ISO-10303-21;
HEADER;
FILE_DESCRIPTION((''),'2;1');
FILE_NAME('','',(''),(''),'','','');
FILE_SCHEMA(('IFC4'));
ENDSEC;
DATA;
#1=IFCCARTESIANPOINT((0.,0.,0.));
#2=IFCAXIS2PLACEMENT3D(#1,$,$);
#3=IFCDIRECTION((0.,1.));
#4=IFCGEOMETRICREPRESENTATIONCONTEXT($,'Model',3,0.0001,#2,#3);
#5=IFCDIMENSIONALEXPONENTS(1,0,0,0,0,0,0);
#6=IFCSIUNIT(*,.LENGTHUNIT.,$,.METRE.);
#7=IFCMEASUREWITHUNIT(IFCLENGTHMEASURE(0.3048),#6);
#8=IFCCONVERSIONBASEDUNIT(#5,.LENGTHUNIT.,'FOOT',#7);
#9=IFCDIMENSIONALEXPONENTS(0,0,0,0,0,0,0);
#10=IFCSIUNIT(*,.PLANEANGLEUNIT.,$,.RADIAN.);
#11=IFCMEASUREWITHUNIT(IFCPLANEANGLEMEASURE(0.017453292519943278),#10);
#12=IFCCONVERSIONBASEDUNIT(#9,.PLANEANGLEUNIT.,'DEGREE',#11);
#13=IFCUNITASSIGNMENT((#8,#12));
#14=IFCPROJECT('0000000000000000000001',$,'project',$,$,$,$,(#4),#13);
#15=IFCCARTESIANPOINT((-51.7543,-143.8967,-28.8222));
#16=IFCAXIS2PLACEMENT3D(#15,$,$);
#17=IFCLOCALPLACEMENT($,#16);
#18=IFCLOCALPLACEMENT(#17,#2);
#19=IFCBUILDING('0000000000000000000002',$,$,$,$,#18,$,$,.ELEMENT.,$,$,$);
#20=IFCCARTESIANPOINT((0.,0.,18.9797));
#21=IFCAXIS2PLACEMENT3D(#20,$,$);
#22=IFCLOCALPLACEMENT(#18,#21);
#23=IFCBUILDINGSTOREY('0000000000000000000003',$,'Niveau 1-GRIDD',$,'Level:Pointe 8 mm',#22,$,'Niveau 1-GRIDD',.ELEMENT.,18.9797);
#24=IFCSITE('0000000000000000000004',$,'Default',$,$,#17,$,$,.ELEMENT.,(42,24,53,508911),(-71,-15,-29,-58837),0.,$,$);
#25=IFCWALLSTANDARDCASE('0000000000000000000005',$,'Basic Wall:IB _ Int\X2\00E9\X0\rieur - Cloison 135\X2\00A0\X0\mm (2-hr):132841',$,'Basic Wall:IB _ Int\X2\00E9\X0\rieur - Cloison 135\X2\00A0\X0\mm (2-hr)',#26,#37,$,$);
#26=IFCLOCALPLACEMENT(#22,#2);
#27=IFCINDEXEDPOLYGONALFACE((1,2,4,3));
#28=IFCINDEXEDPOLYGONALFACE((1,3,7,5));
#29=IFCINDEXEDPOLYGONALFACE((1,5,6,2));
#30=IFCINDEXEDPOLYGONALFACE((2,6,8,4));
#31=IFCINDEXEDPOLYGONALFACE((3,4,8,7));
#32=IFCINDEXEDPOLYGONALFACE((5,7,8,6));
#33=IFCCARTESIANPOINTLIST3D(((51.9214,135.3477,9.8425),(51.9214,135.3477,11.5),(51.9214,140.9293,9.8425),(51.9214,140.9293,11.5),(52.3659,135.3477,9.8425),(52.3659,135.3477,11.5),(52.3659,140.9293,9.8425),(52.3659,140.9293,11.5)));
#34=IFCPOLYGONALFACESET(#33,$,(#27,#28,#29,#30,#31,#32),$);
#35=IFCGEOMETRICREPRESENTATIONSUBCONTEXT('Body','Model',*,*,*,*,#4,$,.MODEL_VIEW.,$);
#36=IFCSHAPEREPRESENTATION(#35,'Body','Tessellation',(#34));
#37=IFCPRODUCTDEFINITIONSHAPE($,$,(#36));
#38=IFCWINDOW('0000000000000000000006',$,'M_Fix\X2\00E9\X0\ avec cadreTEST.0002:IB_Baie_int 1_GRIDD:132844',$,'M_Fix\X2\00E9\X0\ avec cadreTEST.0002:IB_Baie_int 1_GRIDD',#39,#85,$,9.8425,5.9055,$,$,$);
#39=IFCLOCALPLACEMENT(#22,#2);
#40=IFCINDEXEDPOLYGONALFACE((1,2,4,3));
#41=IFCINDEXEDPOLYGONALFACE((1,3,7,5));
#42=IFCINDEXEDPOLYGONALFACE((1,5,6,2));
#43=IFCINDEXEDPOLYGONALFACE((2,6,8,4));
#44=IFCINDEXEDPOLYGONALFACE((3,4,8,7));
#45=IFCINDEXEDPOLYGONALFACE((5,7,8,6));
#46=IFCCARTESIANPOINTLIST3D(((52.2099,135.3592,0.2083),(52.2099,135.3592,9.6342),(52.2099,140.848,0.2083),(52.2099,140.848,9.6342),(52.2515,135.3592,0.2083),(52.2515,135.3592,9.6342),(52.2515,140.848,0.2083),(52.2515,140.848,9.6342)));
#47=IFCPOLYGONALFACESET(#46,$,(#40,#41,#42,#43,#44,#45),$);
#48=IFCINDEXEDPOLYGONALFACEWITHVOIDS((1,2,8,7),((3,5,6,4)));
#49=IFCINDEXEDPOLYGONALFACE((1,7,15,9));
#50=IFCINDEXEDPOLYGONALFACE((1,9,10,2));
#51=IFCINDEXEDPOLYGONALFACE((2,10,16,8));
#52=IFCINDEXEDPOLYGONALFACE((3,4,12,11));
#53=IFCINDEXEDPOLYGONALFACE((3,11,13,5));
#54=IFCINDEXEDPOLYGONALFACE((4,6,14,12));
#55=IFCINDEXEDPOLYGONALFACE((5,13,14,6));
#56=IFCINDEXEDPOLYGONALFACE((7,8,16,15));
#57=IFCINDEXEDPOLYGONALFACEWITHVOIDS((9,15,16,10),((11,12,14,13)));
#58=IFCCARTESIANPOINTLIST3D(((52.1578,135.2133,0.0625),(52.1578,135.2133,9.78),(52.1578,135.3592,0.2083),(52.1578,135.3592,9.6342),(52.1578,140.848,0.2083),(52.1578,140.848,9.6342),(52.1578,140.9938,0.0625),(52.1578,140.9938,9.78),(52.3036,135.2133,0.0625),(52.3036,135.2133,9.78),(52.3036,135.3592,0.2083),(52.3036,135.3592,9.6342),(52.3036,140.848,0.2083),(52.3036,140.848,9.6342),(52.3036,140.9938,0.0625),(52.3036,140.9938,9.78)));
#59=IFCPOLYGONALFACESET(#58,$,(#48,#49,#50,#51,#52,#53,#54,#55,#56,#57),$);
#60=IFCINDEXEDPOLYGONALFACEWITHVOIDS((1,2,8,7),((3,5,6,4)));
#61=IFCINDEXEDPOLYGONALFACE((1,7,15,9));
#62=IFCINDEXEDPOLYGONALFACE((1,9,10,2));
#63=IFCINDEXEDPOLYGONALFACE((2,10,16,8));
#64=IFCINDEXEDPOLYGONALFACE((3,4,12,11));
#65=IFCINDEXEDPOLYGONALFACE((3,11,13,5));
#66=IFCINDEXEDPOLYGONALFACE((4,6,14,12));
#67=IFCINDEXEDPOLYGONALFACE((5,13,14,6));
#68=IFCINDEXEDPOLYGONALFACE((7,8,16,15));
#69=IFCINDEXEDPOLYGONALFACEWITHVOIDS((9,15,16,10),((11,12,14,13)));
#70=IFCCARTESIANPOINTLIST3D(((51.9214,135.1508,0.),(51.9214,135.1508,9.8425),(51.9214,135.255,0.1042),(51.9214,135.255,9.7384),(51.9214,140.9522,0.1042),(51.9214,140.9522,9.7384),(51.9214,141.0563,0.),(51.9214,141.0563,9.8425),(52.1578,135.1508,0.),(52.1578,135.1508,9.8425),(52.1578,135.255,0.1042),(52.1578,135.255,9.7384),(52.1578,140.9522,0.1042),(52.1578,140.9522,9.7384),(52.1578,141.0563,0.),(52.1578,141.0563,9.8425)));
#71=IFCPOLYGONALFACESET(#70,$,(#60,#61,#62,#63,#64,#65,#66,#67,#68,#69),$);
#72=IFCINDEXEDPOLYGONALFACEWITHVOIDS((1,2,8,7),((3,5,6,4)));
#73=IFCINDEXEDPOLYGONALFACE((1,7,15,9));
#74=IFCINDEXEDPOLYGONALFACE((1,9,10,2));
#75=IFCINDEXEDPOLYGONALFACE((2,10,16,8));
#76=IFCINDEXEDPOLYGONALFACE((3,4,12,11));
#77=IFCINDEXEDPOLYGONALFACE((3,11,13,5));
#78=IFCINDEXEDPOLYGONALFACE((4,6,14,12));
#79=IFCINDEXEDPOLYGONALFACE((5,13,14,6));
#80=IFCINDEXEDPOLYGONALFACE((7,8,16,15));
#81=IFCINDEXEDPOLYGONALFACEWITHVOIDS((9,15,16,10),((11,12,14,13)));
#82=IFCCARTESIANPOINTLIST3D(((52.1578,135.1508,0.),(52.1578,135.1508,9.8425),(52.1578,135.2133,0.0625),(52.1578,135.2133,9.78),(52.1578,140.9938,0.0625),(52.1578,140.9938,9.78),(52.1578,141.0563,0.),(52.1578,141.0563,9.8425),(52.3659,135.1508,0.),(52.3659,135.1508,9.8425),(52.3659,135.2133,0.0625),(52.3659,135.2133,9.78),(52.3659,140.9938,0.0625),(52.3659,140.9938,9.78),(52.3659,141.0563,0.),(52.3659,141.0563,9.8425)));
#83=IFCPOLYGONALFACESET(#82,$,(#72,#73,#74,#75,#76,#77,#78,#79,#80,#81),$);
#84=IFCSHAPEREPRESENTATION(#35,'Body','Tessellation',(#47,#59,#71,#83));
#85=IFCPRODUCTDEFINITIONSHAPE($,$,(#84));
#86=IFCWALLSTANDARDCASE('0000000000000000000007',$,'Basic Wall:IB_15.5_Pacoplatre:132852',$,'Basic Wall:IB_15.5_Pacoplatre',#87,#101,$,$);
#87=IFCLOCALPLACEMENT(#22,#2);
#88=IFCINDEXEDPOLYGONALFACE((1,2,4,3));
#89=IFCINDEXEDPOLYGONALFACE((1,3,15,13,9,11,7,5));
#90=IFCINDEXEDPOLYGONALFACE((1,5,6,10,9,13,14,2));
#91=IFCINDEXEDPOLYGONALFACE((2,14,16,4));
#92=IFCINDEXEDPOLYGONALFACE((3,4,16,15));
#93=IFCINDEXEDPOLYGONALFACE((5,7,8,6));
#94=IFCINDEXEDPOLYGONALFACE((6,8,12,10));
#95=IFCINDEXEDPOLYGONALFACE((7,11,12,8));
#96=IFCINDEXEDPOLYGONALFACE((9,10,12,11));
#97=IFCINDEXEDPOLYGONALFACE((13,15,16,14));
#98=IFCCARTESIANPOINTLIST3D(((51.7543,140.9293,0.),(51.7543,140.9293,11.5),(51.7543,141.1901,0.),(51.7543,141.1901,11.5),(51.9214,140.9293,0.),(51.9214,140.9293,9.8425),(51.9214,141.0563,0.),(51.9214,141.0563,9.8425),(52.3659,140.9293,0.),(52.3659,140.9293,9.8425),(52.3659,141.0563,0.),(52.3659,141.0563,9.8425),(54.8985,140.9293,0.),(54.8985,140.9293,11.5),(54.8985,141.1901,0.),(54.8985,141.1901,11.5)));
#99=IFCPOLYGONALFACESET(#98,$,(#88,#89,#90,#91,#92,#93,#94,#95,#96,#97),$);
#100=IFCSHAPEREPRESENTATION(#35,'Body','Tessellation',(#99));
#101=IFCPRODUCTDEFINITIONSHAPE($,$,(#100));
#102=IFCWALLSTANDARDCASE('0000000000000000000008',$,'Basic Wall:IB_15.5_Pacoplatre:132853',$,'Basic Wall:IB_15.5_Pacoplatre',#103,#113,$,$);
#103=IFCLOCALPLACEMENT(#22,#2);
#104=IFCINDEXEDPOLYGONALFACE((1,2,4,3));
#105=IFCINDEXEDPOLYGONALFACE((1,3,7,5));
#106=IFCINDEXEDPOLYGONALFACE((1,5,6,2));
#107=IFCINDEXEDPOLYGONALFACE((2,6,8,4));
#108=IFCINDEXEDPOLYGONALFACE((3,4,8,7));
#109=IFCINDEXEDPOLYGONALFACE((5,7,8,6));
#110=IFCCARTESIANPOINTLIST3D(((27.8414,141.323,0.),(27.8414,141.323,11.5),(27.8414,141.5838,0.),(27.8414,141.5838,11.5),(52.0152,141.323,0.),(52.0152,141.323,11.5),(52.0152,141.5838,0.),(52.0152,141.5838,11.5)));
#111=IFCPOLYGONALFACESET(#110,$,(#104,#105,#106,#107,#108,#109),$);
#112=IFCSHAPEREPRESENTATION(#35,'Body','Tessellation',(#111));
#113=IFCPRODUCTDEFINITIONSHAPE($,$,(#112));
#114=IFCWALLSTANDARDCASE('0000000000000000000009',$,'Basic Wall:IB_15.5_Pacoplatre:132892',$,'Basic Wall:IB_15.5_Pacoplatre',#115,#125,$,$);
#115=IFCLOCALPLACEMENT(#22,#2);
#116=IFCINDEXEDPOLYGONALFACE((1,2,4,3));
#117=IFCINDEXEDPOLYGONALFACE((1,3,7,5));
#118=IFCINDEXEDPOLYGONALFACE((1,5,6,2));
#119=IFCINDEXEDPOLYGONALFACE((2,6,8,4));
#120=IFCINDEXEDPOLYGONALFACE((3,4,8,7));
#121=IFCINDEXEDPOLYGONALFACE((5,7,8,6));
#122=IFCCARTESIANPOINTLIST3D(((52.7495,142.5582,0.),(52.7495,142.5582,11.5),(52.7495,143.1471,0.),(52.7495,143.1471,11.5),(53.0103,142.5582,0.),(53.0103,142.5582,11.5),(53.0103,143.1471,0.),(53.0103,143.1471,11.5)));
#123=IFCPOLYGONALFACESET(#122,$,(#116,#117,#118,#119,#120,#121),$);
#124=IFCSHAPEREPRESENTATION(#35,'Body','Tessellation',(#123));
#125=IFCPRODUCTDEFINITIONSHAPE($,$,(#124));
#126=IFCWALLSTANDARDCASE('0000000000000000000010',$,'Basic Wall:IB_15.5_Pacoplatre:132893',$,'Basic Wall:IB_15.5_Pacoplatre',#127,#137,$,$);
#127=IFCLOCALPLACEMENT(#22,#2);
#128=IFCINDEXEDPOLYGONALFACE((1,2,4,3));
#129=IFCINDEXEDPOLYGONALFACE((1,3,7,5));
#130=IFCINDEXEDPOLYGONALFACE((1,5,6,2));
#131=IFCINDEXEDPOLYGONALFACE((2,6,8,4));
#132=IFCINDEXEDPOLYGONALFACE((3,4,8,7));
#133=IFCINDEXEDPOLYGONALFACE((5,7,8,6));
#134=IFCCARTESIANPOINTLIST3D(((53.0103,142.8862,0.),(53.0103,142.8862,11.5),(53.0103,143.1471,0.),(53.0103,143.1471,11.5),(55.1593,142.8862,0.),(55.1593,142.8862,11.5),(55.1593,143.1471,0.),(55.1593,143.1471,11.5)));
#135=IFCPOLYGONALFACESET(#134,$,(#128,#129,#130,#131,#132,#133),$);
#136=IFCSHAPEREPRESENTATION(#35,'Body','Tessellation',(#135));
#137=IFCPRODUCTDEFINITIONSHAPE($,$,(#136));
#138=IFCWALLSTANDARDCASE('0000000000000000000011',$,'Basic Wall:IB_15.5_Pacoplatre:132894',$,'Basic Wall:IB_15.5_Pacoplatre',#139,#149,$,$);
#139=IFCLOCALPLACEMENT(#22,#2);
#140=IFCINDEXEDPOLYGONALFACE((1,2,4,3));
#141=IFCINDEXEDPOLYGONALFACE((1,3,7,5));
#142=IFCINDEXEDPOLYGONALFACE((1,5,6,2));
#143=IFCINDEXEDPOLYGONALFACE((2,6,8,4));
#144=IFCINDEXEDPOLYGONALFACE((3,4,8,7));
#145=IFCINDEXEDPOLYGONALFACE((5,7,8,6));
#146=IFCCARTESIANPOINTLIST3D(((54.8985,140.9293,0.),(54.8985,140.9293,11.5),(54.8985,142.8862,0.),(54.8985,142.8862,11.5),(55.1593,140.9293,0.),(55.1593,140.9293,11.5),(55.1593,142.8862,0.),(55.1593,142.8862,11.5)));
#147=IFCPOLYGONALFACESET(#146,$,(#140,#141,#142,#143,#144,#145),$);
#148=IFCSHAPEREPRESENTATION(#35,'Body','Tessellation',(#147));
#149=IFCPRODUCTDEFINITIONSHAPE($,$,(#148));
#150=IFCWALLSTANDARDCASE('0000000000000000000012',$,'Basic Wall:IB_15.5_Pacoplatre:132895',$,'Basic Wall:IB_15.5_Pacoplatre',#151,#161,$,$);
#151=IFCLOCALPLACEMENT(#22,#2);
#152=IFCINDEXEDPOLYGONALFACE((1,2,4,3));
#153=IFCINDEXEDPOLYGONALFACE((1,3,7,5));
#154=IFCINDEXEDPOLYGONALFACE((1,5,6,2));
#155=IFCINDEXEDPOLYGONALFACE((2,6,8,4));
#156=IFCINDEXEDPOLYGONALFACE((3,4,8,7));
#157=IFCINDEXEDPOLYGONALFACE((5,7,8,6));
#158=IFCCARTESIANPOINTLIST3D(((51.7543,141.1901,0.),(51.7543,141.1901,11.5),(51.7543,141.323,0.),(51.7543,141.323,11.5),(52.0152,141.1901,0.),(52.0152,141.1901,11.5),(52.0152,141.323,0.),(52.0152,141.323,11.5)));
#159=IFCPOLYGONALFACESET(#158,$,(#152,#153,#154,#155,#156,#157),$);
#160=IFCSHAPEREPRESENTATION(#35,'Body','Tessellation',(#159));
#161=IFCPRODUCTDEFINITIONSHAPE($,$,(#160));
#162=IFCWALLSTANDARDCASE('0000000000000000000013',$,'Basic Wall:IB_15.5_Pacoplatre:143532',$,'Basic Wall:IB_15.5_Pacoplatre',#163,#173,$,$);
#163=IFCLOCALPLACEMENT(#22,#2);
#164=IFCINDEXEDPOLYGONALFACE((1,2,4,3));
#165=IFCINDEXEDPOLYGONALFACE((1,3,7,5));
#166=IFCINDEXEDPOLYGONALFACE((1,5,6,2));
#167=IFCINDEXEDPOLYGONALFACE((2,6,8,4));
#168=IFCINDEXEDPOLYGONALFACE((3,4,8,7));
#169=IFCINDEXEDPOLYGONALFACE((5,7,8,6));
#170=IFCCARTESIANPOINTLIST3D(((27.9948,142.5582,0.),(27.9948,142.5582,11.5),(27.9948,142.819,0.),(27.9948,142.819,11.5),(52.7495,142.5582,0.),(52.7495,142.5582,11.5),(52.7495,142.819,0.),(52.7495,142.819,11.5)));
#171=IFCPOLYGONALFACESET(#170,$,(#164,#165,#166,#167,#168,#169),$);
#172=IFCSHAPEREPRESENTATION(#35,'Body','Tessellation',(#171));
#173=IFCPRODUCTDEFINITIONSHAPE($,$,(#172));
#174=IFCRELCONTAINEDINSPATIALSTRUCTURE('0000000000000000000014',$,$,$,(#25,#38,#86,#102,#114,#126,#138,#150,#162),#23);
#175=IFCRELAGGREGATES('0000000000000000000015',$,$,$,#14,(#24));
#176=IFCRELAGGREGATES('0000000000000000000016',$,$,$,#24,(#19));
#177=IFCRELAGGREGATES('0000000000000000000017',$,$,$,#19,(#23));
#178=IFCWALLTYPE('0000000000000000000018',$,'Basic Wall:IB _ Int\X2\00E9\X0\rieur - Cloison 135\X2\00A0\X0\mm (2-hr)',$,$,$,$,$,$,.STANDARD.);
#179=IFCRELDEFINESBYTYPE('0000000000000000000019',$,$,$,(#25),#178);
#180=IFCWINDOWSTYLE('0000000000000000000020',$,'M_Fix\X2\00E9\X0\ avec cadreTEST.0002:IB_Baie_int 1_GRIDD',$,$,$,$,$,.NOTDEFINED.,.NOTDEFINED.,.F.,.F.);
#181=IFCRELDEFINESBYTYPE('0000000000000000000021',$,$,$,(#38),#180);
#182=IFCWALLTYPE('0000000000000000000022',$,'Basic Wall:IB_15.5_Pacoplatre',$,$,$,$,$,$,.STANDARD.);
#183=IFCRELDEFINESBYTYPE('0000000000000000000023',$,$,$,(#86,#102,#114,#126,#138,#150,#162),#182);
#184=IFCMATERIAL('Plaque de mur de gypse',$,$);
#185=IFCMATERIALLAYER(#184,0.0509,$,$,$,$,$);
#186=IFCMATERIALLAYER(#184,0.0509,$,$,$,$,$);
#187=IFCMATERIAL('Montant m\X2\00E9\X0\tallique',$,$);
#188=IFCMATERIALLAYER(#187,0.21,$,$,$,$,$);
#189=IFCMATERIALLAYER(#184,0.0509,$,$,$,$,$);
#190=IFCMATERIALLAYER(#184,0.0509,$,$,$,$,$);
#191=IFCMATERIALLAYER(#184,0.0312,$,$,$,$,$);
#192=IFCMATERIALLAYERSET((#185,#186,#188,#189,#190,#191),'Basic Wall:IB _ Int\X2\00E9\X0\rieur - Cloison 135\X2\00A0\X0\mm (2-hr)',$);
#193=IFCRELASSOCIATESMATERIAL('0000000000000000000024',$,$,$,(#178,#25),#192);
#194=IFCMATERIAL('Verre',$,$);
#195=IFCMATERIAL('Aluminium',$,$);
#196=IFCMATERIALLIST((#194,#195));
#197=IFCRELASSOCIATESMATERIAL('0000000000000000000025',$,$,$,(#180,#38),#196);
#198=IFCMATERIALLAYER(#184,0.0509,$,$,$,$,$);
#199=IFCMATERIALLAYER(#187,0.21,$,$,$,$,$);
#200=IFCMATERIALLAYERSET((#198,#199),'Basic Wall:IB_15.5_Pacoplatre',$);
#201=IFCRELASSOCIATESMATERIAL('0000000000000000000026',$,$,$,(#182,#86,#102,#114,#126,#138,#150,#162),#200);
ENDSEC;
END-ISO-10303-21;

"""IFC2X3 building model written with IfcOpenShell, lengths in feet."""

from ifc_helpers import new_model, entity, si_unit, converted_unit, direction, frame, frame_2d, origin, place, context, subcontext, project, spatial, polyline, rectangle, outline, extrude, source, transform, mapped, material, material_list, layer, layer_set, layer_usage, type_object, type_shapes, element, fill, save


model = new_model("IFC2X3")

# Units and contexts
model_context = context("Model", 3, precision=0.0001, world=origin(), true_north=direction((0.0, 1.0)))
body_context = subcontext(model_context, "Body", "Model", "MODEL_VIEW")
ifc_project = project(units=[converted_unit("LENGTHUNIT", "FOOT", entity("IfcLengthMeasure", 0.3048), si_unit("LENGTHUNIT", "METRE"), dimensions=[1, 0, 0, 0, 0, 0, 0]), converted_unit("PLANEANGLEUNIT", "DEGREE", entity("IfcPlaneAngleMeasure", 0.017453292519943278), si_unit("PLANEANGLEUNIT", "RADIAN"), dimensions=[0, 0, 0, 0, 0, 0, 0])], contexts=[model_context])

# Site, building, storey
site_placement = place(None, frame((-51.7543, -143.8967, -28.8222)))
site = spatial("IfcSite", under=ifc_project, at=site_placement, Name="Default", CompositionType="ELEMENT", RefLatitude=(42, 24, 53, 508911), RefLongitude=(-71, -15, -29, -58837), RefElevation=0.0)
building_placement = place(site_placement, origin())
building = spatial("IfcBuilding", under=site, at=building_placement, CompositionType="ELEMENT")
storey_placement = place(building_placement, frame((0.0, 0.0, 18.9797)))
storey = spatial("IfcBuildingStorey", under=building, at=storey_placement, Name="Niveau 1-GRIDD", ObjectType="Level:Pointe 8 mm", LongName="Niveau 1-GRIDD", CompositionType="ELEMENT", Elevation=18.9797)

# Shared definitions
ifc_material_1 = material(Name="Plaque de mur de gypse")
ifc_material_2 = material(Name="Montant métallique")
ifc_material_3 = material(Name="Aluminium")
ifc_material_4 = material(Name="Verre")
ifc_material_list_1 = material_list([ifc_material_4, ifc_material_3])

# Wall, opening, window
ifc_layer_1 = layer(ifc_material_1, 0.0509)
ifc_layer_2 = layer(ifc_material_1, 0.0509)
ifc_layer_3 = layer(ifc_material_2, 0.21)
ifc_layer_4 = layer(ifc_material_1, 0.0509)
ifc_layer_5 = layer(ifc_material_1, 0.0509)
ifc_layer_6 = layer(ifc_material_1, 0.0312)
ifc_layer_set_1 = layer_set([ifc_layer_1, ifc_layer_2, ifc_layer_3, ifc_layer_4, ifc_layer_5, ifc_layer_6], Name="Basic Wall:IB _ Intérieur - Cloison 135 mm (2-hr)")
ifc_layer_usage_1 = layer_usage(ifc_layer_set_1, "AXIS2", "NEGATIVE", 0.2223)
wall_type_1 = type_object("IfcWallType", Name="Basic Wall:IB _ Intérieur - Cloison 135 mm (2-hr)", PredefinedType="STANDARD", material=ifc_layer_set_1)
wall_1_placement = place(storey_placement, frame((52.1437, 140.9293, 9.8425), z_axis=(0.0, 0.0, 1.0), x_axis=(0.0, -1.0, 0.0)))
wall_1 = element("IfcWallStandardCase", 1, at=wall_1_placement, inside=storey, type_object=wall_type_1, material=ifc_layer_usage_1, Name="Basic Wall:IB _ Intérieur - Cloison 135 mm (2-hr):132841", ObjectType="Basic Wall:IB _ Intérieur - Cloison 135 mm (2-hr)", context=body_context, shape_type="SweptSolid", body=[
    extrude(rectangle(XDim=5.5816, YDim=0.4446, at=frame_2d((2.7908, 0.0), x_axis=(1.0, 0.0))), origin(), (0.0, 0.0, 1.0), 1.6575),
])
opening_1_placement = place(wall_1_placement, frame((-0.1271, -0.2223, -9.8425)))
opening_1 = element("IfcOpeningElement", 2, at=opening_1_placement, cuts=wall_1, ObjectType="Opening", context=body_context, shape_type="SweptSolid", body=[
    extrude(rectangle(XDim=9.8425, YDim=5.9055, at=frame_2d((4.9213, 2.9528), x_axis=(-1.0, 0.0))), frame((0.0, 0.0, 0.0), z_axis=(0.0, 1.0, 0.0), x_axis=(0.0, 0.0, 1.0)), (0.0, 0.0, 1.0), 0.4446),
])
window_style_1 = type_object("IfcWindowStyle", Name="M_Fixé avec cadreTEST.0002:IB_Baie_int 1_GRIDD", ConstructionType="NOTDEFINED", OperationType="NOTDEFINED", ParameterTakesPrecedence=False, Sizeable=False, material=ifc_material_list_1)
shared_shape_1 = source(origin(), body_context, "Body", "SweptSolid", [
    extrude(rectangle(XDim=0.0417, YDim=5.4888, at=frame_2d((0.0, 0.0), x_axis=(1.0, 0.0))), frame((2.9528, 0.3093, 0.2083), z_axis=(0.0, 0.0, 1.0), x_axis=(0.0, 1.0, 0.0)), (0.0, 0.0, 1.0), 9.4259),
    extrude(outline(polyline([(-2.8903, -4.8588), (2.8903, -4.8588), (2.8903, 4.8588), (-2.8903, 4.8588), (-2.8903, -4.8588)]), holes=[polyline([(-2.7444, -4.7129), (-2.7444, 4.7129), (2.7444, 4.7129), (2.7444, -4.7129), (-2.7444, -4.7129)])]), frame((2.9528, 0.2364, 4.9213), z_axis=(0.0, 1.0, 0.0), x_axis=(1.0, 0.0, 0.0)), (0.0, 0.0, 1.0), 0.1458),
    extrude(outline(polyline([(-2.9528, -4.9213), (2.9528, -4.9213), (2.9528, 4.9213), (-2.9528, 4.9213), (-2.9528, -4.9213)]), holes=[polyline([(-2.8486, -4.8171), (-2.8486, 4.8171), (2.8486, 4.8171), (2.8486, -4.8171), (-2.8486, -4.8171)])]), frame((2.9528, 0.0, 4.9213), z_axis=(0.0, 1.0, 0.0), x_axis=(1.0, 0.0, 0.0)), (0.0, 0.0, 1.0), 0.2364),
    extrude(outline(polyline([(-4.9213, -2.9528), (4.9213, -2.9528), (4.9213, 2.9528), (-4.9213, 2.9528), (-4.9213, -2.9528)]), holes=[polyline([(-4.8588, -2.8903), (-4.8588, 2.8903), (4.8588, 2.8903), (4.8588, -2.8903), (-4.8588, -2.8903)])]), frame((2.9528, 0.2364, 4.9213), z_axis=(0.0, 1.0, 0.0), x_axis=(0.0, 0.0, -1.0)), (0.0, 0.0, 1.0), 0.2082),
])
type_shapes(window_style_1, [shared_shape_1])
window_1_placement = place(opening_1_placement, origin())
window_1 = element("IfcWindow", 3, at=window_1_placement, inside=storey, type_object=window_style_1, material=ifc_material_list_1, Name="M_Fixé avec cadreTEST.0002:IB_Baie_int 1_GRIDD:132844", ObjectType="M_Fixé avec cadreTEST.0002:IB_Baie_int 1_GRIDD", OverallHeight=9.8425, OverallWidth=5.9055, context=body_context, shape_type="MappedRepresentation", body=[
    mapped(shared_shape_1, transform((0.0, 0.0, 0.0), scale=1.0)),
])
fill(opening_1, window_1)

# Wall, opening
ifc_layer_7 = layer(ifc_material_1, 0.0509)
ifc_layer_8 = layer(ifc_material_2, 0.21)
ifc_layer_set_2 = layer_set([ifc_layer_7, ifc_layer_8], Name="Basic Wall:IB_15.5_Pacoplatre")
ifc_layer_usage_2 = layer_usage(ifc_layer_set_2, "AXIS2", "NEGATIVE", 0.1304)
wall_type_2 = type_object("IfcWallType", Name="Basic Wall:IB_15.5_Pacoplatre", PredefinedType="STANDARD", material=ifc_layer_set_2)
wall_2_placement = place(storey_placement, frame((54.8985, 141.0597, 0.0), z_axis=(0.0, 0.0, 1.0), x_axis=(-1.0, 0.0, 0.0)))
wall_2 = element("IfcWallStandardCase", 4, at=wall_2_placement, inside=storey, type_object=wall_type_2, material=ifc_layer_usage_2, Name="Basic Wall:IB_15.5_Pacoplatre:132852", ObjectType="Basic Wall:IB_15.5_Pacoplatre", context=body_context, shape_type="SweptSolid", body=[
    extrude(rectangle(XDim=3.1441, YDim=0.2608, at=frame_2d((1.5721, 0.0), x_axis=(-1.0, 0.0))), origin(), (0.0, 0.0, 1.0), 11.5),
])
opening_2_placement = place(wall_2_placement, origin())
element("IfcOpeningElement", 5, at=opening_2_placement, cuts=wall_2, ObjectType="Opening", context=body_context, shape_type="SweptSolid", body=[
    extrude(rectangle(XDim=9.8425, YDim=0.4446, at=frame_2d((0.0, 0.0), x_axis=(0.0, 1.0))), frame((2.7548, 0.0034, 4.9213), z_axis=(0.0, 1.0, 0.0), x_axis=(1.0, 0.0, 0.0)), (0.0, 0.0, 1.0), 5.9055),
])

# Walls
ifc_layer_usage_3 = layer_usage(ifc_layer_set_2, "AXIS2", "NEGATIVE", 0.1304)
wall_3_placement = place(storey_placement, frame((52.0152, 141.4534, 0.0), z_axis=(0.0, 0.0, 1.0), x_axis=(-1.0, 0.0, 0.0)))
element("IfcWallStandardCase", 6, at=wall_3_placement, inside=storey, type_object=wall_type_2, material=ifc_layer_usage_3, Name="Basic Wall:IB_15.5_Pacoplatre:132853", ObjectType="Basic Wall:IB_15.5_Pacoplatre", context=body_context, shape_type="SweptSolid", body=[
    extrude(rectangle(XDim=24.1738, YDim=0.2608, at=frame_2d((12.0869, 0.0), x_axis=(-1.0, 0.0))), origin(), (0.0, 0.0, 1.0), 11.5),
])
ifc_layer_usage_4 = layer_usage(ifc_layer_set_2, "AXIS2", "NEGATIVE", 0.1304)
wall_4_placement = place(storey_placement, frame((52.8799, 142.5582, 0.0), z_axis=(0.0, 0.0, 1.0), x_axis=(0.0, 1.0, 0.0)))
element("IfcWallStandardCase", 7, at=wall_4_placement, inside=storey, type_object=wall_type_2, material=ifc_layer_usage_4, Name="Basic Wall:IB_15.5_Pacoplatre:132892", ObjectType="Basic Wall:IB_15.5_Pacoplatre", context=body_context, shape_type="SweptSolid", body=[
    extrude(rectangle(XDim=0.5889, YDim=0.2608, at=frame_2d((0.2945, 0.0), x_axis=(-1.0, 0.0))), origin(), (0.0, 0.0, 1.0), 11.5),
])
ifc_layer_usage_5 = layer_usage(ifc_layer_set_2, "AXIS2", "NEGATIVE", 0.1304)
wall_5_placement = place(storey_placement, frame((53.0103, 143.0167, 0.0)))
element("IfcWallStandardCase", 8, at=wall_5_placement, inside=storey, type_object=wall_type_2, material=ifc_layer_usage_5, Name="Basic Wall:IB_15.5_Pacoplatre:132893", ObjectType="Basic Wall:IB_15.5_Pacoplatre", context=body_context, shape_type="SweptSolid", body=[
    extrude(rectangle(XDim=2.149, YDim=0.2608, at=frame_2d((1.0745, 0.0), x_axis=(-1.0, 0.0))), origin(), (0.0, 0.0, 1.0), 11.5),
])
ifc_layer_usage_6 = layer_usage(ifc_layer_set_2, "AXIS2", "NEGATIVE", 0.1304)
wall_6_placement = place(storey_placement, frame((55.0289, 142.8862, 0.0), z_axis=(0.0, 0.0, 1.0), x_axis=(0.0, -1.0, 0.0)))
element("IfcWallStandardCase", 9, at=wall_6_placement, inside=storey, type_object=wall_type_2, material=ifc_layer_usage_6, Name="Basic Wall:IB_15.5_Pacoplatre:132894", ObjectType="Basic Wall:IB_15.5_Pacoplatre", context=body_context, shape_type="SweptSolid", body=[
    extrude(rectangle(XDim=1.9569, YDim=0.2608, at=frame_2d((0.9785, 0.0), x_axis=(-1.0, 0.0))), origin(), (0.0, 0.0, 1.0), 11.5),
])
ifc_layer_usage_7 = layer_usage(ifc_layer_set_2, "AXIS2", "NEGATIVE", 0.1304)
wall_7_placement = place(storey_placement, frame((51.8848, 141.323, 0.0), z_axis=(0.0, 0.0, 1.0), x_axis=(0.0, -1.0, 0.0)))
element("IfcWallStandardCase", 10, at=wall_7_placement, inside=storey, type_object=wall_type_2, material=ifc_layer_usage_7, Name="Basic Wall:IB_15.5_Pacoplatre:132895", ObjectType="Basic Wall:IB_15.5_Pacoplatre", context=body_context, shape_type="SweptSolid", body=[
    extrude(rectangle(XDim=0.1329, YDim=0.2608, at=frame_2d((0.0664, 0.0), x_axis=(-1.0, 0.0))), origin(), (0.0, 0.0, 1.0), 11.5),
])
ifc_layer_usage_8 = layer_usage(ifc_layer_set_2, "AXIS2", "NEGATIVE", 0.1304)
wall_8_placement = place(storey_placement, frame((52.7495, 142.6886, 0.0), z_axis=(0.0, 0.0, 1.0), x_axis=(-1.0, 0.0, 0.0)))
element("IfcWallStandardCase", 11, at=wall_8_placement, inside=storey, type_object=wall_type_2, material=ifc_layer_usage_8, Name="Basic Wall:IB_15.5_Pacoplatre:143532", ObjectType="Basic Wall:IB_15.5_Pacoplatre", context=body_context, shape_type="SweptSolid", body=[
    extrude(rectangle(XDim=24.7548, YDim=0.2608, at=frame_2d((12.3774, 0.0), x_axis=(-1.0, 0.0))), origin(), (0.0, 0.0, 1.0), 11.5),
])

save(model, "model.ifc")
